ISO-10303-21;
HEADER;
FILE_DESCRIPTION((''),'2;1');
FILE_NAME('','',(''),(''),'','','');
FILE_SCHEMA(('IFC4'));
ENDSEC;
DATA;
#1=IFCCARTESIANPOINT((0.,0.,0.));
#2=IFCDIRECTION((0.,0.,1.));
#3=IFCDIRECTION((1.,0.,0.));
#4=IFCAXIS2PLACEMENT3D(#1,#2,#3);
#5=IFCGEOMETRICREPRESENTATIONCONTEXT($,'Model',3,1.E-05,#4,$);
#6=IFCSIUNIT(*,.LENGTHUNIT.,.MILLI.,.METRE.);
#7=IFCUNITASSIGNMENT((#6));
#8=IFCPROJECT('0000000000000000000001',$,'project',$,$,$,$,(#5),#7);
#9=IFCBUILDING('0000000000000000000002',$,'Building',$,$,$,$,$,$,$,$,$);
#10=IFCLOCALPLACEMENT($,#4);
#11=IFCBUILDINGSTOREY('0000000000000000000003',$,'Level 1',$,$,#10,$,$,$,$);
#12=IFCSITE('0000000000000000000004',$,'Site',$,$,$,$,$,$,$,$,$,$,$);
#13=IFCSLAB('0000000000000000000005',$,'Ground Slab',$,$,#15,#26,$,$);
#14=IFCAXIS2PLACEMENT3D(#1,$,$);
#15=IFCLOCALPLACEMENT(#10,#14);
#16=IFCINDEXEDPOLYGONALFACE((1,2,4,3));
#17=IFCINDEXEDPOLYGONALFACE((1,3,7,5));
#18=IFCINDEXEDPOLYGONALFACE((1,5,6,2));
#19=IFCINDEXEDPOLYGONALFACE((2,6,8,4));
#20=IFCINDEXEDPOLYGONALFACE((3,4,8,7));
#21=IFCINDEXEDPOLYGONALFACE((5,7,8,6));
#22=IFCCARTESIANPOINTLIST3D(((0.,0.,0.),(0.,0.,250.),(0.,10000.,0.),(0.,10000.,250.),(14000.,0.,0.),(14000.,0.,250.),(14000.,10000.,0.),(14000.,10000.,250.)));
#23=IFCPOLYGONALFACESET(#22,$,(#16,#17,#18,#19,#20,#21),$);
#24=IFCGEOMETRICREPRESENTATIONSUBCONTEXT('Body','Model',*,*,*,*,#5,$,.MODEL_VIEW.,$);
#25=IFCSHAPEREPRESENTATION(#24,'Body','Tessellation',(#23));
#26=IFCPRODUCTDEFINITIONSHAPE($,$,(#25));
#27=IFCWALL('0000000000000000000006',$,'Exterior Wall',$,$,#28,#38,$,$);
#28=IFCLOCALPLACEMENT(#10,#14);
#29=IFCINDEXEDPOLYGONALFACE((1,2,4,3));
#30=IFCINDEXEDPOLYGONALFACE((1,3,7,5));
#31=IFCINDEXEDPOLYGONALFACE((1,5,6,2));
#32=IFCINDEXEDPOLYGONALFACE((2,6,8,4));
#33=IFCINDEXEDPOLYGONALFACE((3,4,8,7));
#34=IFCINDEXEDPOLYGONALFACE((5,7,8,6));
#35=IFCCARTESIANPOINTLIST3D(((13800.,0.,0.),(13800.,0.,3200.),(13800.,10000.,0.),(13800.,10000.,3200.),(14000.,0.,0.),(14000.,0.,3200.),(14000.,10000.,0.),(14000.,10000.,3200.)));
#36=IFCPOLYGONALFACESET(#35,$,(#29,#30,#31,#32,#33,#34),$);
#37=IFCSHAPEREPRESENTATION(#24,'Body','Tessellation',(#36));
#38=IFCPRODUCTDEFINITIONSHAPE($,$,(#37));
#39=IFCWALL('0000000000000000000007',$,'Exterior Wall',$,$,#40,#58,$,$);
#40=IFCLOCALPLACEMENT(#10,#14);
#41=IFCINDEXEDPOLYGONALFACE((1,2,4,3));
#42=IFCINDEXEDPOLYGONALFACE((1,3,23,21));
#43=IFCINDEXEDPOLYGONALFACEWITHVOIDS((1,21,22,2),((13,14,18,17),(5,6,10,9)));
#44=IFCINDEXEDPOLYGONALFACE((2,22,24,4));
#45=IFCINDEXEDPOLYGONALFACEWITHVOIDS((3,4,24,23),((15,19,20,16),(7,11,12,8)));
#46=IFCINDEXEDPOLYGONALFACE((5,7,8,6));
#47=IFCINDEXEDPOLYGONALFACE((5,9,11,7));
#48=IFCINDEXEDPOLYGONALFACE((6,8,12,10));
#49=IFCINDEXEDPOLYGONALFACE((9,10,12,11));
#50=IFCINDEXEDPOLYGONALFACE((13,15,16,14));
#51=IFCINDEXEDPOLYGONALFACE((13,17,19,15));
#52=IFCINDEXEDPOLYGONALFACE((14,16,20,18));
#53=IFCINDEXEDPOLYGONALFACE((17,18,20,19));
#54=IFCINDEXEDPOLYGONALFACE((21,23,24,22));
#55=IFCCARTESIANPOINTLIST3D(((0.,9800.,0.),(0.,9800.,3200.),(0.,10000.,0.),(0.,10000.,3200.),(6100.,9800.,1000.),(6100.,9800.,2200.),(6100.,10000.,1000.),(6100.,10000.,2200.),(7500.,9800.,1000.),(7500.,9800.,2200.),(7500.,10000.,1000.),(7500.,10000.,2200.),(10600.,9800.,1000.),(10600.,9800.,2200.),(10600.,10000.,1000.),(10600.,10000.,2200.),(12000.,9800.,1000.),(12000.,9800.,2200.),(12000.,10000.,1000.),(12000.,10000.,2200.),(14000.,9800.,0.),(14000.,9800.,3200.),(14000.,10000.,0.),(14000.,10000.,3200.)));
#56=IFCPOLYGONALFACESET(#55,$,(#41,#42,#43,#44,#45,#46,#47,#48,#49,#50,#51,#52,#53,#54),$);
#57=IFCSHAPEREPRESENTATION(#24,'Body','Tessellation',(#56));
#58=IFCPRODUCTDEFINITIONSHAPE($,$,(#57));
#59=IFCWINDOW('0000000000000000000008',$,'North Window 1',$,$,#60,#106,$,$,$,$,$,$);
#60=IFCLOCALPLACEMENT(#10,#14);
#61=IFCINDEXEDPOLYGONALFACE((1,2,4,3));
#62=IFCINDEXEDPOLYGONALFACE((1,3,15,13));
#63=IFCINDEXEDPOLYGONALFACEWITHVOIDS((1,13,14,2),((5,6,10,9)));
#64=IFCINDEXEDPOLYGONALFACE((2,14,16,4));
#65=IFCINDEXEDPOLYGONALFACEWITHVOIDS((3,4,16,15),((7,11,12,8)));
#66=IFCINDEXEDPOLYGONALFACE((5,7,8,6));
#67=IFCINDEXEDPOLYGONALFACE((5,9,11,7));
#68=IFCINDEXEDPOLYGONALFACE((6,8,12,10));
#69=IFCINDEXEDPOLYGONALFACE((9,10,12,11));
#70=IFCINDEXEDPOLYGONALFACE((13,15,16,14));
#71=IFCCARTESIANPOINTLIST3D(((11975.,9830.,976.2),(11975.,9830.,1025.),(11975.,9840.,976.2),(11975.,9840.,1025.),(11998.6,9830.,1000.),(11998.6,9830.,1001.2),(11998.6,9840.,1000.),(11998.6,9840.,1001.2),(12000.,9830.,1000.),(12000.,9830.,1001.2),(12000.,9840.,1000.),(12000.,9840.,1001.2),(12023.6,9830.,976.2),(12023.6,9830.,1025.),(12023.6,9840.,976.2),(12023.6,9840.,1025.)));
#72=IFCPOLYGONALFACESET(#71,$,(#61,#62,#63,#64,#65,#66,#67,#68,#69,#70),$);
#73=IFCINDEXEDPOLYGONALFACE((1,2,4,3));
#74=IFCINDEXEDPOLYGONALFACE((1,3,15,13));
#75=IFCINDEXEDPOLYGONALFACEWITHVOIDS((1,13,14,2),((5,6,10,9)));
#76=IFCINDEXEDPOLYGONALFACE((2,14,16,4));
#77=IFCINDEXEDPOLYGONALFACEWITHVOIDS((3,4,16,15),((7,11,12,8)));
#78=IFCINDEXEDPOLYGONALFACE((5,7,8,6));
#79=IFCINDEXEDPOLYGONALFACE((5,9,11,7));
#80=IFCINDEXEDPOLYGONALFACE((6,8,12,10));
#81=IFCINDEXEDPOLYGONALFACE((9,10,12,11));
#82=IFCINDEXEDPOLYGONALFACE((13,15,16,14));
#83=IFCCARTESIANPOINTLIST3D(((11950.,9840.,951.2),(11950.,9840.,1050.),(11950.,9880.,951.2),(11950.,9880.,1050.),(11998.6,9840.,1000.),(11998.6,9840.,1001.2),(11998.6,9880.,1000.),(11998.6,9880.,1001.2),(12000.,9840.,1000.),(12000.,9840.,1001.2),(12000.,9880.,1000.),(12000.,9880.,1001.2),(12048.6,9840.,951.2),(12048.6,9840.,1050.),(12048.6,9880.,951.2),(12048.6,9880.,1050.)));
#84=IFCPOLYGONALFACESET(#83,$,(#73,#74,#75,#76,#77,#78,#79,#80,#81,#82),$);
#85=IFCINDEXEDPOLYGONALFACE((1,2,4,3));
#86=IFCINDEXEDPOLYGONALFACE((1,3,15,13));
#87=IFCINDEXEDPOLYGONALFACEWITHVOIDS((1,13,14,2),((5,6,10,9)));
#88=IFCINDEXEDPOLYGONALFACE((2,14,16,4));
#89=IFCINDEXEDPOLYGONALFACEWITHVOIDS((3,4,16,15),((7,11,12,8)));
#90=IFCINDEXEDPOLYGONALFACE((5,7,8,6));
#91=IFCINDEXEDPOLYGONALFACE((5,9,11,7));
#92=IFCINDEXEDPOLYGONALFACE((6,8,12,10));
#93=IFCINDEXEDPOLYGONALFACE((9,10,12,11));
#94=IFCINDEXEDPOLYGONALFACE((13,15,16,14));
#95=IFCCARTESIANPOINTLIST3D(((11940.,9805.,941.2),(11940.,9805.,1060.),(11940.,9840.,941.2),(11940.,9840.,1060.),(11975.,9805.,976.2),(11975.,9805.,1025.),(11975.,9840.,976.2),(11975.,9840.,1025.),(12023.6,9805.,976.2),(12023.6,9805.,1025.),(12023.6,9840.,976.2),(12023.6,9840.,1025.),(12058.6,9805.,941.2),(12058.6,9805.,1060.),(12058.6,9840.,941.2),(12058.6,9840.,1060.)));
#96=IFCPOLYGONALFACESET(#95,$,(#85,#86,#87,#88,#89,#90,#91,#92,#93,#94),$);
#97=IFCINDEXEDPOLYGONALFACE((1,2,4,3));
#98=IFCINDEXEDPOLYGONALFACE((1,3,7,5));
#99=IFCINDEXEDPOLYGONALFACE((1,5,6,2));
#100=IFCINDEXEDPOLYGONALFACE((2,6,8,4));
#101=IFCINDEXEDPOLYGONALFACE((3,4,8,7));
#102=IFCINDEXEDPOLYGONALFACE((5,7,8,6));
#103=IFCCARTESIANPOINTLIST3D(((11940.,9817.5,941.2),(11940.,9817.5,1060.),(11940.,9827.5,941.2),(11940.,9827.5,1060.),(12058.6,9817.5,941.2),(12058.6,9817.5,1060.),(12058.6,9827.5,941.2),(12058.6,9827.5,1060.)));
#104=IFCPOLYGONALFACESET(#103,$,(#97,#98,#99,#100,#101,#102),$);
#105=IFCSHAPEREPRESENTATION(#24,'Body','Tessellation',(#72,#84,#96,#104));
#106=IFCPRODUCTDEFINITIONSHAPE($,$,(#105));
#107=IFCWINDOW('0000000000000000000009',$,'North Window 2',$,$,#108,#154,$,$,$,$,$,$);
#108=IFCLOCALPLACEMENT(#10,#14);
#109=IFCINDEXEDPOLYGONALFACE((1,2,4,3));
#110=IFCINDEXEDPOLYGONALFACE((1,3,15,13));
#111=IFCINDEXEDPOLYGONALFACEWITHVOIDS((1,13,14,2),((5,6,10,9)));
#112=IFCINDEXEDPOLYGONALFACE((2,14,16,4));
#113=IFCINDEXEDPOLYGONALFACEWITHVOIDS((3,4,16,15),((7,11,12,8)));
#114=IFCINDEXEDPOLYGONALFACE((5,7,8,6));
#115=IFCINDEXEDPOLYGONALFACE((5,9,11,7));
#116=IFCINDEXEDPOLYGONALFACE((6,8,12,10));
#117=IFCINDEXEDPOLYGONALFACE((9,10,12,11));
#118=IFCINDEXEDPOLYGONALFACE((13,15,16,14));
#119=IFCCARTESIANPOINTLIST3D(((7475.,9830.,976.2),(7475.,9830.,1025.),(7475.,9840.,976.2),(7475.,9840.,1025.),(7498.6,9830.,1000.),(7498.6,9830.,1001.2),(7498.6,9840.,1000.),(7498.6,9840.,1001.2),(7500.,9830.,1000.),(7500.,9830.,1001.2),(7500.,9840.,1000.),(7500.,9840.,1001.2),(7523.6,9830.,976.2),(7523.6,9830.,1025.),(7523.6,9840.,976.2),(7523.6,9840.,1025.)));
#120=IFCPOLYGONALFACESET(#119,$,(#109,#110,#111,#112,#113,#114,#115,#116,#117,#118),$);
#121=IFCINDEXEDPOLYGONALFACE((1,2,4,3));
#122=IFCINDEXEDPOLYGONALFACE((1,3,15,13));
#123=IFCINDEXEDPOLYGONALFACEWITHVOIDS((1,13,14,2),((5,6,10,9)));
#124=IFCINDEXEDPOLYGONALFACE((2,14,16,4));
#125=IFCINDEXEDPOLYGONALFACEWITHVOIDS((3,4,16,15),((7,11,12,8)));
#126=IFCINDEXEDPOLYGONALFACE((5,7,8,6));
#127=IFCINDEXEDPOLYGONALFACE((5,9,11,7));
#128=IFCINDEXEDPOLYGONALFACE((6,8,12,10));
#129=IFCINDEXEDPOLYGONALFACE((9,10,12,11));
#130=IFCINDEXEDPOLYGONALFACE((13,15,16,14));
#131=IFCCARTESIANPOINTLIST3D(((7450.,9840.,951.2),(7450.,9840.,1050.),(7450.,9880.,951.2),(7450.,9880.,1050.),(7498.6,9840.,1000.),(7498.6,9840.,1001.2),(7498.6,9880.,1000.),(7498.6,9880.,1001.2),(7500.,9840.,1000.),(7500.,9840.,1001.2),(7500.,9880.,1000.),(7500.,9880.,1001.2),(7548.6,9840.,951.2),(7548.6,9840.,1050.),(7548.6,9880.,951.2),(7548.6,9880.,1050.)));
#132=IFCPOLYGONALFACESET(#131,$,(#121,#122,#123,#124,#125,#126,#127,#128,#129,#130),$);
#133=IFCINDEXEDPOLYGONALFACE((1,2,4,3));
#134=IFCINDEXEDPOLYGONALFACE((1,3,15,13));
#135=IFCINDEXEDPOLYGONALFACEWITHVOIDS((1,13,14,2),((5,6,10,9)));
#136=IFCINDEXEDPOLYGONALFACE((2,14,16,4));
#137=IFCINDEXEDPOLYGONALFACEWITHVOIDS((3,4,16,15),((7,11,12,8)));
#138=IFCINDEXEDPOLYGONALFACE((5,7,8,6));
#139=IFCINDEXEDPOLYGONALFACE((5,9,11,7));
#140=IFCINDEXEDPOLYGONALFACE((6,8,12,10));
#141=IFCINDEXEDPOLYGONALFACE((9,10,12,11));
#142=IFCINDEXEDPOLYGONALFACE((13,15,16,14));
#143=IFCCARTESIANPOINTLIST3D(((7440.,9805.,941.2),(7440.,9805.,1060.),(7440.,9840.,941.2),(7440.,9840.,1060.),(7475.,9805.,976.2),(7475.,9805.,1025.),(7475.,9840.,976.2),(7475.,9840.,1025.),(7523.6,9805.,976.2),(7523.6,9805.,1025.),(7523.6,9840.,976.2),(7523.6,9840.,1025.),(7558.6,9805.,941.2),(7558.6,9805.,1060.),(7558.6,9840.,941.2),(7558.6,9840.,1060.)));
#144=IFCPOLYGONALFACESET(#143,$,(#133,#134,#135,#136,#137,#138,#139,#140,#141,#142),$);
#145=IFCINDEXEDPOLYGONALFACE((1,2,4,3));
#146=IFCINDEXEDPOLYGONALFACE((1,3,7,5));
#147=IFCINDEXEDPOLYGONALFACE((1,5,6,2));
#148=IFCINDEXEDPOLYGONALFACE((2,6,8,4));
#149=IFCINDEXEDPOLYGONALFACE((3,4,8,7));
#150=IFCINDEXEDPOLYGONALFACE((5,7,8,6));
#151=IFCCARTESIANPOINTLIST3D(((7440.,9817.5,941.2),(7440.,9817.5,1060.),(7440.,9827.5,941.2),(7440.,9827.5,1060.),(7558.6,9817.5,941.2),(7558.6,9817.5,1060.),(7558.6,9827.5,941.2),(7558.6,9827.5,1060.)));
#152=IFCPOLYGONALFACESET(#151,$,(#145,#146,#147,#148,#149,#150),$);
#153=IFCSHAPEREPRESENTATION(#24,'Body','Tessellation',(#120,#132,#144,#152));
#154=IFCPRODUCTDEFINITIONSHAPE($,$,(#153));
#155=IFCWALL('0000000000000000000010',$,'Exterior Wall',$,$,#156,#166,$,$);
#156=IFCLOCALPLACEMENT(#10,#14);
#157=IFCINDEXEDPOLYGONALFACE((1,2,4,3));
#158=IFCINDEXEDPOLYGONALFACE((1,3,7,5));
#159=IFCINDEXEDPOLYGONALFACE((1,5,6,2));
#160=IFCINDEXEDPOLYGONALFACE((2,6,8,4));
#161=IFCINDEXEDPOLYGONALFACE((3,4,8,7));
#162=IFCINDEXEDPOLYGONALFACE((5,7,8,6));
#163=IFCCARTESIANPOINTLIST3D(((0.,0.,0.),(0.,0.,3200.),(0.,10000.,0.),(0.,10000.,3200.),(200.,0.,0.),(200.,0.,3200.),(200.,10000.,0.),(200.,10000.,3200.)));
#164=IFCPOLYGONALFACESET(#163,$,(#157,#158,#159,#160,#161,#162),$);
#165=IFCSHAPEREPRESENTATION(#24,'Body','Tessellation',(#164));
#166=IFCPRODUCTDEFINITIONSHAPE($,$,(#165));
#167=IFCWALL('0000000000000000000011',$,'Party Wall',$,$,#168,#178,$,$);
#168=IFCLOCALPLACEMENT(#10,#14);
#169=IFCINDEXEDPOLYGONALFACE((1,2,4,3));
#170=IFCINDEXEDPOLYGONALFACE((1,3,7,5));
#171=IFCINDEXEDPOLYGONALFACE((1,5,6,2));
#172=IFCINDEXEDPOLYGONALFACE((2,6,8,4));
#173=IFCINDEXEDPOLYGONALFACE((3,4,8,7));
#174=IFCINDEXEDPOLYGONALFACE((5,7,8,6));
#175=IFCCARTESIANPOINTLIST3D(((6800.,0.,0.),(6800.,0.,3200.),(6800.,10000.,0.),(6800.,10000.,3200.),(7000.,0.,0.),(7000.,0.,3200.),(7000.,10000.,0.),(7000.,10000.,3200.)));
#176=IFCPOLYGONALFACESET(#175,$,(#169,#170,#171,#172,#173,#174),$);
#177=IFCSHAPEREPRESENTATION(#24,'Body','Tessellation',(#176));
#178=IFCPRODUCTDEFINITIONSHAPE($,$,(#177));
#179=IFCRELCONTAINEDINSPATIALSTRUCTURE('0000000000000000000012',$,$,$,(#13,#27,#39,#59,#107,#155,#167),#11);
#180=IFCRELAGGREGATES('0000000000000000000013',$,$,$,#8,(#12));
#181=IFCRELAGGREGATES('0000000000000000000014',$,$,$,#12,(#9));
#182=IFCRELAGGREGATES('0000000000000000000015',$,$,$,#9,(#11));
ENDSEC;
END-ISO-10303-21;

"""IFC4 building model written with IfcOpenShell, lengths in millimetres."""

from ifc_helpers import new_model, si_unit, frame, origin_with_axes, place, context, subcontext, project, spatial, line, indexed_curve, outline, extrude, element, fill, save


model = new_model("IFC4")

# Units and contexts
model_context = context("Model", 3, precision=1e-05, world=origin_with_axes())
body_context = subcontext(model_context, "Body", "Model", "MODEL_VIEW")
ifc_project = project(units=[si_unit("LENGTHUNIT", "METRE", prefix="MILLI")], contexts=[model_context])

# Site, building, storey
site = spatial("IfcSite", under=ifc_project, Name="Site")
building = spatial("IfcBuilding", under=site, Name="Building")
storey_placement = place(None, origin_with_axes())
storey = spatial("IfcBuildingStorey", under=building, at=storey_placement, Name="Level 1")

# Slab
slab_placement = place(storey_placement, origin_with_axes())
element("IfcSlab", 1, at=slab_placement, inside=storey, Name="Ground Slab", context=body_context, shape_type="SweptSolid", body=[
    extrude(outline(indexed_curve([(0.0, 0.0), (14000.0, 0.0), (14000.0, 10000.0), (0.0, 10000.0), (0.0, 0.0)])), None, (0.0, 0.0, 1.0), 250.0),
])

# Wall
wall_1_placement = place(storey_placement, frame((14000.0, 0.0, 0.0), z_axis=(0.0, 0.0, 1.0), x_axis=(0.0, 1.0, 0.0)))
element("IfcWall", 2, at=wall_1_placement, inside=storey, Name="Exterior Wall", context=body_context, shape_type="SweptSolid", body=[
    extrude(outline(indexed_curve([(0.0, 0.0), (0.0, 200.0), (10000.0, 200.0), (10000.0, 0.0), (0.0, 0.0)], self_intersect=False)), origin_with_axes(), (0.0, 0.0, 1.0), 3200.0),
])

# Wall, openings, windows
wall_2_placement = place(storey_placement, frame((14000.0, 10000.0, 0.0), z_axis=(0.0, 0.0, 1.0), x_axis=(-1.0, 0.0, 0.0)))
wall_2 = element("IfcWall", 3, at=wall_2_placement, inside=storey, Name="Exterior Wall", context=body_context, shape_type="SweptSolid", body=[
    extrude(outline(indexed_curve([(0.0, 0.0), (0.0, 200.0), (14000.0, 200.0), (14000.0, 0.0), (0.0, 0.0)], self_intersect=False)), origin_with_axes(), (0.0, 0.0, 1.0), 3200.0),
])
opening_1_placement = place(wall_2_placement, frame((2000.0, -100.0, 1000.0), z_axis=(0.0, 0.0, 1.0), x_axis=(1.0, 0.0, 0.0)))
opening_1 = element("IfcOpeningElement", 4, at=opening_1_placement, cuts=wall_2, context=body_context, shape_type="SweptSolid", body=[
    extrude(outline(indexed_curve([(0.0, 0.0), (0.0, 400.0), (1400.0, 400.0), (1400.0, 0.0), (0.0, 0.0)], self_intersect=False)), origin_with_axes(), (0.0, 0.0, 1.0), 1200.0),
])
opening_2_placement = place(wall_2_placement, frame((6500.0, -100.0, 1000.0), z_axis=(0.0, 0.0, 1.0), x_axis=(1.0, 0.0, 0.0)))
opening_2 = element("IfcOpeningElement", 5, at=opening_2_placement, cuts=wall_2, context=body_context, shape_type="SweptSolid", body=[
    extrude(outline(indexed_curve([(0.0, 0.0), (0.0, 400.0), (1400.0, 400.0), (1400.0, 0.0), (0.0, 0.0)], self_intersect=False)), origin_with_axes(), (0.0, 0.0, 1.0), 1200.0),
])
window_1_placement = place(opening_1_placement, frame((0.0, 170.0, 0.0), z_axis=(0.0, 0.0, 1.0), x_axis=(1.0, 0.0, 0.0)))
window_1 = element("IfcWindow", 6, at=window_1_placement, inside=storey, Name="North Window 1", context=body_context, shape_type="SweptSolid", body=[
    extrude(outline(indexed_curve([(0.0, 0.0), (1.4, 0.0), (1.4, 1.2), (0.0, 1.2)], segments=[line(1, 2, 3, 4, 1)]), holes=[indexed_curve([(25.0, 25.0), (-23.6, 25.0), (-23.6, -23.8), (25.0, -23.8)], segments=[line(1, 2, 3, 4, 1)])]), frame((0.0, 90.0, 0.0), z_axis=(0.0, -1.0, 0.0), x_axis=(1.0, 0.0, 0.0)), (0.0, 0.0, -1.0), 10.0),
    extrude(outline(indexed_curve([(0.0, 0.0), (1.4, 0.0), (1.4, 1.2), (0.0, 1.2)], segments=[line(1, 2, 3, 4, 1)]), holes=[indexed_curve([(50.0, 50.0), (-48.6, 50.0), (-48.6, -48.8), (50.0, -48.8)], segments=[line(1, 2, 3, 4, 1)])]), frame((0.0, 50.0, 0.0), z_axis=(0.0, -1.0, 0.0), x_axis=(1.0, 0.0, 0.0)), (0.0, 0.0, -1.0), 40.0),
    extrude(outline(indexed_curve([(0.0, 0.0), (-48.6, 0.0), (-48.6, -48.8), (0.0, -48.8)], segments=[line(1, 2, 3, 4, 1)]), holes=[indexed_curve([(35.0, 35.0), (-83.6, 35.0), (-83.6, -83.8), (35.0, -83.8)], segments=[line(1, 2, 3, 4, 1)])]), frame((25.0, 90.0, 25.0), z_axis=(0.0, -1.0, 0.0), x_axis=(1.0, 0.0, 0.0)), (0.0, 0.0, -1.0), 35.0),
    extrude(outline(indexed_curve([(35.0, 35.0), (-83.6, 35.0), (-83.6, -83.8), (35.0, -83.8)], segments=[line(1, 2, 3, 4, 1)])), frame((25.0, 102.5, 25.0), z_axis=(0.0, -1.0, 0.0), x_axis=(1.0, 0.0, 0.0)), (0.0, 0.0, -1.0), 10.0),
])
fill(opening_1, window_1)
window_2_placement = place(opening_2_placement, frame((0.0, 170.0, 0.0), z_axis=(0.0, 0.0, 1.0), x_axis=(1.0, 0.0, 0.0)))
window_2 = element("IfcWindow", 7, at=window_2_placement, inside=storey, Name="North Window 2", context=body_context, shape_type="SweptSolid", body=[
    extrude(outline(indexed_curve([(0.0, 0.0), (1.4, 0.0), (1.4, 1.2), (0.0, 1.2)], segments=[line(1, 2, 3, 4, 1)]), holes=[indexed_curve([(25.0, 25.0), (-23.6, 25.0), (-23.6, -23.8), (25.0, -23.8)], segments=[line(1, 2, 3, 4, 1)])]), frame((0.0, 90.0, 0.0), z_axis=(0.0, -1.0, 0.0), x_axis=(1.0, 0.0, 0.0)), (0.0, 0.0, -1.0), 10.0),
    extrude(outline(indexed_curve([(0.0, 0.0), (1.4, 0.0), (1.4, 1.2), (0.0, 1.2)], segments=[line(1, 2, 3, 4, 1)]), holes=[indexed_curve([(50.0, 50.0), (-48.6, 50.0), (-48.6, -48.8), (50.0, -48.8)], segments=[line(1, 2, 3, 4, 1)])]), frame((0.0, 50.0, 0.0), z_axis=(0.0, -1.0, 0.0), x_axis=(1.0, 0.0, 0.0)), (0.0, 0.0, -1.0), 40.0),
    extrude(outline(indexed_curve([(0.0, 0.0), (-48.6, 0.0), (-48.6, -48.8), (0.0, -48.8)], segments=[line(1, 2, 3, 4, 1)]), holes=[indexed_curve([(35.0, 35.0), (-83.6, 35.0), (-83.6, -83.8), (35.0, -83.8)], segments=[line(1, 2, 3, 4, 1)])]), frame((25.0, 90.0, 25.0), z_axis=(0.0, -1.0, 0.0), x_axis=(1.0, 0.0, 0.0)), (0.0, 0.0, -1.0), 35.0),
    extrude(outline(indexed_curve([(35.0, 35.0), (-83.6, 35.0), (-83.6, -83.8), (35.0, -83.8)], segments=[line(1, 2, 3, 4, 1)])), frame((25.0, 102.5, 25.0), z_axis=(0.0, -1.0, 0.0), x_axis=(1.0, 0.0, 0.0)), (0.0, 0.0, -1.0), 10.0),
])
fill(opening_2, window_2)

# Walls
for number, where, z_axis, x_axis, name in (
    (8, (0.0, 10000.0, 0.0), (0.0, 0.0, 1.0), (0.0, -1.0, 0.0), "Exterior Wall"),
    (9, (7000.0, 0.0, 0.0), (0.0, 0.0, 1.0), (0.0, 1.0, 0.0), "Party Wall"),
):
    element("IfcWall", number, at=place(storey_placement, frame(where, z_axis=z_axis, x_axis=x_axis)), inside=storey, Name=name, context=body_context, shape_type="SweptSolid", body=[
        extrude(outline(indexed_curve([(0.0, 0.0), (0.0, 200.0), (10000.0, 200.0), (10000.0, 0.0), (0.0, 0.0)], self_intersect=False)), origin_with_axes(), (0.0, 0.0, 1.0), 3200.0),
    ])

save(model, "model.ifc")
